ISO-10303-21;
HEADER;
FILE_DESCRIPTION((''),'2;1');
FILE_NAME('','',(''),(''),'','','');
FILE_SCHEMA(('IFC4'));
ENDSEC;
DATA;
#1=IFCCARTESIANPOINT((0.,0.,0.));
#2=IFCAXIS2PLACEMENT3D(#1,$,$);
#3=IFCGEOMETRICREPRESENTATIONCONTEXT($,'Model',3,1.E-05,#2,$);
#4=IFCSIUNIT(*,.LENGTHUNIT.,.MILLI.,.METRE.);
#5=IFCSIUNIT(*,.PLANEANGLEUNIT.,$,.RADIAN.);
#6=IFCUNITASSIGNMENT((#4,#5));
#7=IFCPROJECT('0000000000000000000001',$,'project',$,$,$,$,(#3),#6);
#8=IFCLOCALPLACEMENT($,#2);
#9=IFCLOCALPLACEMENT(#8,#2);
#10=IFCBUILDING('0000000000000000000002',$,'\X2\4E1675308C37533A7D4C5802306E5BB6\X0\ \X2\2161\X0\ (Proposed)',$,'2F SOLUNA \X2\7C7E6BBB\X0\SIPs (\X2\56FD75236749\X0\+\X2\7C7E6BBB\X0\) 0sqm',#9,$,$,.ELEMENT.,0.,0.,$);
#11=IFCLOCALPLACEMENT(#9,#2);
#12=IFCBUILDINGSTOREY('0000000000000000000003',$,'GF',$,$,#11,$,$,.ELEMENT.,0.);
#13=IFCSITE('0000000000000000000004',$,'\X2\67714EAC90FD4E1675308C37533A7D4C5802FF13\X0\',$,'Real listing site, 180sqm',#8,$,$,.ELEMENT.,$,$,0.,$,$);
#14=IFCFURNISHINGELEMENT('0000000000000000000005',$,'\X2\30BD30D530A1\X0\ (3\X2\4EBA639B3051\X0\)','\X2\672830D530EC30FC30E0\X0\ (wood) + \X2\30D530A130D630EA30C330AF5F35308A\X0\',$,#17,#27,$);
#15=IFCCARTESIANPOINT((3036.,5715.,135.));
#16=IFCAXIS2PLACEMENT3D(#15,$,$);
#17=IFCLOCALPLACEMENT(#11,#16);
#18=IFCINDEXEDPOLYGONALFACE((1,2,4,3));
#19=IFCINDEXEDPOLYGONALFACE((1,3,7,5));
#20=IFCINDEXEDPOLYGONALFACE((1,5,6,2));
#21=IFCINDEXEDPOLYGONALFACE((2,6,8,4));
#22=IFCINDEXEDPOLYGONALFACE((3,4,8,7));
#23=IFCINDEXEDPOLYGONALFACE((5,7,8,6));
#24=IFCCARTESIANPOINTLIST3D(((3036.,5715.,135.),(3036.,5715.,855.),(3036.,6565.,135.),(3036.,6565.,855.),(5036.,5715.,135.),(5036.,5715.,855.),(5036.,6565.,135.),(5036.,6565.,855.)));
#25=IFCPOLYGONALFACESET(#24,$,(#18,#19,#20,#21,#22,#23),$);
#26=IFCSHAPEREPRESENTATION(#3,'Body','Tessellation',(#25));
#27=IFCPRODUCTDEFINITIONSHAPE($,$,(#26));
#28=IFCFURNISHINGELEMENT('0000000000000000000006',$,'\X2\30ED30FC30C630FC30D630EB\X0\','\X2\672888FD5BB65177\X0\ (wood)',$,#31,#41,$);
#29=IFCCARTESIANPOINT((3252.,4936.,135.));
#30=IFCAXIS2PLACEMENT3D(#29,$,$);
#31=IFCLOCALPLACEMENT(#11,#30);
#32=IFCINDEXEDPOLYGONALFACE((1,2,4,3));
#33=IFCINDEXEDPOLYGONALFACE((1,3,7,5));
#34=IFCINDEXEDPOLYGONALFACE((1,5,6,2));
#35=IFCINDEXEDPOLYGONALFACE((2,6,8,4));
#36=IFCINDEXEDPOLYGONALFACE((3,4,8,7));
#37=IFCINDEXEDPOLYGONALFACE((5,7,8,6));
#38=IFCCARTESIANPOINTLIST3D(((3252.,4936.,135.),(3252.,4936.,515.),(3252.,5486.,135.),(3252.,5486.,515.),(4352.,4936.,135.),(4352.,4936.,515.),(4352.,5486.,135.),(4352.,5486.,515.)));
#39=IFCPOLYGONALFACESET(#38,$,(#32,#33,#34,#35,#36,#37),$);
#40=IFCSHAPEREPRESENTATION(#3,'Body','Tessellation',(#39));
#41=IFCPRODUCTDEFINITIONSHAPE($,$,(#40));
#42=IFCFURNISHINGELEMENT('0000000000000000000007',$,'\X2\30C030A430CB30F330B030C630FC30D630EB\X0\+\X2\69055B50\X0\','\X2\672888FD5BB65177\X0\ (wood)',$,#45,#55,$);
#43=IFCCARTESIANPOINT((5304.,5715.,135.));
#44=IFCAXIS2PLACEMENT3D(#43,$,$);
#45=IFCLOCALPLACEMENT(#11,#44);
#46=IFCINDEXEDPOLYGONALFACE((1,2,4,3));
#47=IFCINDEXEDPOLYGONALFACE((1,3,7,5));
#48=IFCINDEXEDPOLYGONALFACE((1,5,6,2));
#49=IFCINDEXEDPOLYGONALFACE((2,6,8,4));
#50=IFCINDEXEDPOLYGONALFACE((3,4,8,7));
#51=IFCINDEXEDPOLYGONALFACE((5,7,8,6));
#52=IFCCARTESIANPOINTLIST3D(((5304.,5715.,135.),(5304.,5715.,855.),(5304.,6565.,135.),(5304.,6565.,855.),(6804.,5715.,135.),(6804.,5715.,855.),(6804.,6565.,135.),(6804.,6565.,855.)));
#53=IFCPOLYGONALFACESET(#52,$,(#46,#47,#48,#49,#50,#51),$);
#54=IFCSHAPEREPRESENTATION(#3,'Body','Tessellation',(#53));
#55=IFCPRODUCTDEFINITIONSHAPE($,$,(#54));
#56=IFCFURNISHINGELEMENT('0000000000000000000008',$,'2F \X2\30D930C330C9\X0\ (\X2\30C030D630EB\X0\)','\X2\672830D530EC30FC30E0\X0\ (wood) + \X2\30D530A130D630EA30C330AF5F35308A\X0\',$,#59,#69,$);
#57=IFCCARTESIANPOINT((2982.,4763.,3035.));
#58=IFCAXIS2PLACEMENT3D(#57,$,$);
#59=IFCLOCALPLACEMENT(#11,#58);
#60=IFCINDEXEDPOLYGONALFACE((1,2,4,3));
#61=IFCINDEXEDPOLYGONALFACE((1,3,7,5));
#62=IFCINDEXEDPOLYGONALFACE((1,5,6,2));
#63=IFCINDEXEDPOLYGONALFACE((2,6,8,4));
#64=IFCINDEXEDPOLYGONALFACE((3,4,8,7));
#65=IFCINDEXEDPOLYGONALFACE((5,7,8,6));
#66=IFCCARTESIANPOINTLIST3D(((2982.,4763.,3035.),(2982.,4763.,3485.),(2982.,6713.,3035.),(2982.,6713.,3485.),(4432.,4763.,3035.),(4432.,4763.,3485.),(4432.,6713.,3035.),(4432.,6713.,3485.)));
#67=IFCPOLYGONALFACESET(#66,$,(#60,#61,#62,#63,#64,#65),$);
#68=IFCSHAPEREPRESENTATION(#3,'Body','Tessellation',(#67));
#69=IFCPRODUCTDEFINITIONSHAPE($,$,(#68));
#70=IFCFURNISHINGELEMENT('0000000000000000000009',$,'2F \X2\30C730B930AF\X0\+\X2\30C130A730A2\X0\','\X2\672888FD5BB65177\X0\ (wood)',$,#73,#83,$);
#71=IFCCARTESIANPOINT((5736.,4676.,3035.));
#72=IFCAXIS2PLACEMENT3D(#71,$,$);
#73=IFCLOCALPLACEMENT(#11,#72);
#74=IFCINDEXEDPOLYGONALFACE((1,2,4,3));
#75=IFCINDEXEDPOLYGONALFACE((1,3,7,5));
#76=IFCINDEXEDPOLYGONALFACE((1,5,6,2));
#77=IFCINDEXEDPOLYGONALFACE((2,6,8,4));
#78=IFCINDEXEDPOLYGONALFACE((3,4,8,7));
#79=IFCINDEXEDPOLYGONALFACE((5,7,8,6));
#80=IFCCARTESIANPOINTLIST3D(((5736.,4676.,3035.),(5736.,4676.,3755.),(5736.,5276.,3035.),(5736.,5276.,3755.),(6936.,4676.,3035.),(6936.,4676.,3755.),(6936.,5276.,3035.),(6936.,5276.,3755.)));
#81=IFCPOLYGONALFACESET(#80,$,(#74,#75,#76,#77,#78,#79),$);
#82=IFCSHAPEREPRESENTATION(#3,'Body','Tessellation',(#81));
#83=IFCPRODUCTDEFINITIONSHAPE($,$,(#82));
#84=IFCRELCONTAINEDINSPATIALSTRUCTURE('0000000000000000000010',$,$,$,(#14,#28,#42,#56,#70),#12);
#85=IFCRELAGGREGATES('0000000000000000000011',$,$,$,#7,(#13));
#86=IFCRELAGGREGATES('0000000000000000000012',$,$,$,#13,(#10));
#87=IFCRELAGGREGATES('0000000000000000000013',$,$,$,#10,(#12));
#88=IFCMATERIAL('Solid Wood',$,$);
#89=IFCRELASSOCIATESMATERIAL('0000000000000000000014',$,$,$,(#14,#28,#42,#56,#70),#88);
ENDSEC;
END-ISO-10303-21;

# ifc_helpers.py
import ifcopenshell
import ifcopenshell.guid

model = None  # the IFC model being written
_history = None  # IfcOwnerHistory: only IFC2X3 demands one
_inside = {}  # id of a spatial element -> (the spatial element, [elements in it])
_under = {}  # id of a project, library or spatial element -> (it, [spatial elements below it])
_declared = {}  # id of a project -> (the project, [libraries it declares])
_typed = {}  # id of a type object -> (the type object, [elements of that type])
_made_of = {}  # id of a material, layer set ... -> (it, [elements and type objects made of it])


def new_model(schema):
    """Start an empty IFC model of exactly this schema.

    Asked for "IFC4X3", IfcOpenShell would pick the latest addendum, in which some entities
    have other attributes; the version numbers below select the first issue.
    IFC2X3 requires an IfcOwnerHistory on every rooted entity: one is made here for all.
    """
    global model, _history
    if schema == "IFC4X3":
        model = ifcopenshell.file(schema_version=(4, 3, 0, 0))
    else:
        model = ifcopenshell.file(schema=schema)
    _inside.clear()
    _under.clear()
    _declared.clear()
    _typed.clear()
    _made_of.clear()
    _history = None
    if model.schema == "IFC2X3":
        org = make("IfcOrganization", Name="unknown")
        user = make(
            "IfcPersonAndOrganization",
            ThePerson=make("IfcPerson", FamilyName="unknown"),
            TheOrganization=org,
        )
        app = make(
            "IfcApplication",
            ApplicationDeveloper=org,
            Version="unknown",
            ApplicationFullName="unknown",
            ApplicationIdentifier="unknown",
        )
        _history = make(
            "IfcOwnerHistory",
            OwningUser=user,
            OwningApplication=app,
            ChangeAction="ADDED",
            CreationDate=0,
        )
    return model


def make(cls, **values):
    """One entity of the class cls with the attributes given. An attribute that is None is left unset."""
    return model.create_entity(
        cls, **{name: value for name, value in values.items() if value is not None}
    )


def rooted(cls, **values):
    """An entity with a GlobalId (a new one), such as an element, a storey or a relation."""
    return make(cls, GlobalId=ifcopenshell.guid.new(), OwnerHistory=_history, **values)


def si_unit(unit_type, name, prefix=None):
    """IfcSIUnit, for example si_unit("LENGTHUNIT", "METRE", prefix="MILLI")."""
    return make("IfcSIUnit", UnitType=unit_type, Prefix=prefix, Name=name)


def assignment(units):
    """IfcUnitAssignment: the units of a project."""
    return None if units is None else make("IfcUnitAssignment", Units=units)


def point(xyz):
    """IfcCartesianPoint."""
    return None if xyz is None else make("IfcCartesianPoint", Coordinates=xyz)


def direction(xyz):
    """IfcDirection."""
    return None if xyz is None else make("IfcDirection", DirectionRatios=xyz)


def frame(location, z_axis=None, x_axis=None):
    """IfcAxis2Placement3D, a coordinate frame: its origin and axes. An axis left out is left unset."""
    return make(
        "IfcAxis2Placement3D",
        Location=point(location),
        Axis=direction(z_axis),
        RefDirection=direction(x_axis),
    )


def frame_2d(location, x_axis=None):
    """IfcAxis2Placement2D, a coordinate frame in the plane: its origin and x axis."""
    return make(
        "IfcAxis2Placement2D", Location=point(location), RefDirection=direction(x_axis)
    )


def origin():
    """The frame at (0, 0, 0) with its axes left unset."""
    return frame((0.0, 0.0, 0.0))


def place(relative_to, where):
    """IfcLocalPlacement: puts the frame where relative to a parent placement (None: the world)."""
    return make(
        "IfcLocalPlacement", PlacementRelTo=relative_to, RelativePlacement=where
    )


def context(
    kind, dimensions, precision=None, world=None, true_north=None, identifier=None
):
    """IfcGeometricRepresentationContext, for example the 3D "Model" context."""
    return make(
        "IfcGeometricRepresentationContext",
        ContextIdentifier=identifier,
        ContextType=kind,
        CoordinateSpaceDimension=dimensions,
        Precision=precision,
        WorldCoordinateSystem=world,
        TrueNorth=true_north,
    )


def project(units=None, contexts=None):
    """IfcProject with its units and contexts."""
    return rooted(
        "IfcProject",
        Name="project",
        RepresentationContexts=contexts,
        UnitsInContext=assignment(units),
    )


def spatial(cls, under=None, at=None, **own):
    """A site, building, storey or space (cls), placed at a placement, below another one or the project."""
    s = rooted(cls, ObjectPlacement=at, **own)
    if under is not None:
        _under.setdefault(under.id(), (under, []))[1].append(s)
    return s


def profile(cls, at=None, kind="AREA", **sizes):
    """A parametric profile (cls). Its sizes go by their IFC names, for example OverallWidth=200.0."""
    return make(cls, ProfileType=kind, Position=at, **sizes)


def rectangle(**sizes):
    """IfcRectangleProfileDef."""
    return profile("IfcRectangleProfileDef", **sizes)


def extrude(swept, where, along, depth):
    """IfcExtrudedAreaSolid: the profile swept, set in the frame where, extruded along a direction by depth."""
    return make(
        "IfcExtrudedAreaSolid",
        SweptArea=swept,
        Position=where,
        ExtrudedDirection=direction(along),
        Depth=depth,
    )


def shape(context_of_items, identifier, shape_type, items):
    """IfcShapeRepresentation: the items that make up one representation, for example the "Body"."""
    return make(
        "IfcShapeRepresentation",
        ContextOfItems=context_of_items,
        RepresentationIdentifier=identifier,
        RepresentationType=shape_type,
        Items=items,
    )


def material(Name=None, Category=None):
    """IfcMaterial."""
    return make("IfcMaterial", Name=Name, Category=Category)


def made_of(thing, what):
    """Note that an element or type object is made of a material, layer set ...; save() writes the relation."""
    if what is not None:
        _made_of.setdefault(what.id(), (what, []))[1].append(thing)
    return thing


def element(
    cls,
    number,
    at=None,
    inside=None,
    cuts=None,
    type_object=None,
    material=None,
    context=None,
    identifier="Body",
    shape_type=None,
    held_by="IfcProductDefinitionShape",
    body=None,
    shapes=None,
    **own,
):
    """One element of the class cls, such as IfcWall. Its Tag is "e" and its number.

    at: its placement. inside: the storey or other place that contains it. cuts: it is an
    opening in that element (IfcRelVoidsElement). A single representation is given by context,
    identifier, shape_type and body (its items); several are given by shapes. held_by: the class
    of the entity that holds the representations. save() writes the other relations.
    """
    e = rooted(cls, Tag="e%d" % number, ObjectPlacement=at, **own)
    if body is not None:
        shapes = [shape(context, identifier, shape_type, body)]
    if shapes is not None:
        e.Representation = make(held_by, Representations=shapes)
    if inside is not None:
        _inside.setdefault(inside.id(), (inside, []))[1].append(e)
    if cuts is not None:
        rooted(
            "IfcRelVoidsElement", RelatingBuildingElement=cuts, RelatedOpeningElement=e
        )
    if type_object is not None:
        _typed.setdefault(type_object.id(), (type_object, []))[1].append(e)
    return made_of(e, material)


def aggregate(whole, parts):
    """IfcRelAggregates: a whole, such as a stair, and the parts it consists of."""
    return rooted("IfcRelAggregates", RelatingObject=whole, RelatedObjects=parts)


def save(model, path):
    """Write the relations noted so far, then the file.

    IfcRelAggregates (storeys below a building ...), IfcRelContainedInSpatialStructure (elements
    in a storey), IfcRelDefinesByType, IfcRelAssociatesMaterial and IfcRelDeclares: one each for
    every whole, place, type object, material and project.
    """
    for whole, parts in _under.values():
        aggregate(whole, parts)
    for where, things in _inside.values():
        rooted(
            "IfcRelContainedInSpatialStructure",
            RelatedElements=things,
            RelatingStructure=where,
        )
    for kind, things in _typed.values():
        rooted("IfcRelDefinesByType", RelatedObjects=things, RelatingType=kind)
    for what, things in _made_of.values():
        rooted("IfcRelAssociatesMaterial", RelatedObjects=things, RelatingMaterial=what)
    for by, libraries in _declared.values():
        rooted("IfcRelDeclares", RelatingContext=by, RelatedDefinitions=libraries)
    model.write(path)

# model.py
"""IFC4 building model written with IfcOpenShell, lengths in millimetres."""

from ifc_helpers import new_model, si_unit, frame, frame_2d, origin, place, context, project, spatial, rectangle, extrude, material, element, save


model = new_model("IFC4")

# Units and contexts
model_context = context("Model", 3, precision=1e-05, world=origin())
ifc_project = project(units=[si_unit("LENGTHUNIT", "METRE", prefix="MILLI"), si_unit("PLANEANGLEUNIT", "RADIAN")], contexts=[model_context])

# Site, building, storey
site_placement = place(None, origin())
site = spatial("IfcSite", under=ifc_project, at=site_placement, Name="東京都世田谷区経堂３", ObjectType="Real listing site, 180sqm", CompositionType="ELEMENT", RefElevation=0.0)
building_placement = place(site_placement, origin())
building = spatial("IfcBuilding", under=site, at=building_placement, Name="世田谷区経堂の家 Ⅱ (Proposed)", ObjectType="2F SOLUNA 籾殻SIPs (国産杉+籾殻) 0sqm", CompositionType="ELEMENT", ElevationOfRefHeight=0.0, ElevationOfTerrain=0.0)
storey_placement = place(building_placement, origin())
storey = spatial("IfcBuildingStorey", under=building, at=storey_placement, Name="GF", CompositionType="ELEMENT", Elevation=0.0)

# Shared definitions
ifc_material_1 = material(Name="Solid Wood")

# Furnishing elements
furnishing_1_placement = place(storey_placement, frame((3036.0, 5715.0, 135.0)))
element("IfcFurnishingElement", 1, at=furnishing_1_placement, inside=storey, material=ifc_material_1, Name="ソファ (3人掛け)", Description="木フレーム (wood) + ファブリック張り", context=model_context, shape_type="SweptSolid", body=[
    extrude(rectangle(XDim=2000.0, YDim=850.0, at=frame_2d((1000.0, 425.0))), frame((3036.0, 5715.0, 135.0)), (0.0, 0.0, 1.0), 720.0),
])
furnishing_2_placement = place(storey_placement, frame((3252.0, 4936.0, 135.0)))
element("IfcFurnishingElement", 2, at=furnishing_2_placement, inside=storey, material=ifc_material_1, Name="ローテーブル", Description="木製家具 (wood)", context=model_context, shape_type="SweptSolid", body=[
    extrude(rectangle(XDim=1100.0, YDim=550.0, at=frame_2d((550.0, 275.0))), frame((3252.0, 4936.0, 135.0)), (0.0, 0.0, 1.0), 380.0),
])
furnishing_3_placement = place(storey_placement, frame((5304.0, 5715.0, 135.0)))
element("IfcFurnishingElement", 3, at=furnishing_3_placement, inside=storey, material=ifc_material_1, Name="ダイニングテーブル+椅子", Description="木製家具 (wood)", context=model_context, shape_type="SweptSolid", body=[
    extrude(rectangle(XDim=1500.0, YDim=850.0, at=frame_2d((750.0, 425.0))), frame((5304.0, 5715.0, 135.0)), (0.0, 0.0, 1.0), 720.0),
])
furnishing_4_placement = place(storey_placement, frame((2982.0, 4763.0, 3035.0)))
element("IfcFurnishingElement", 4, at=furnishing_4_placement, inside=storey, material=ifc_material_1, Name="2F ベッド (ダブル)", Description="木フレーム (wood) + ファブリック張り", context=model_context, shape_type="SweptSolid", body=[
    extrude(rectangle(XDim=1450.0, YDim=1950.0, at=frame_2d((725.0, 975.0))), frame((2982.0, 4763.0, 3035.0)), (0.0, 0.0, 1.0), 450.0),
])
furnishing_5_placement = place(storey_placement, frame((5736.0, 4676.0, 3035.0)))
element("IfcFurnishingElement", 5, at=furnishing_5_placement, inside=storey, material=ifc_material_1, Name="2F デスク+チェア", Description="木製家具 (wood)", context=model_context, shape_type="SweptSolid", body=[
    extrude(rectangle(XDim=1200.0, YDim=600.0, at=frame_2d((600.0, 300.0))), frame((5736.0, 4676.0, 3035.0)), (0.0, 0.0, 1.0), 720.0),
])

save(model, "model.ifc")
